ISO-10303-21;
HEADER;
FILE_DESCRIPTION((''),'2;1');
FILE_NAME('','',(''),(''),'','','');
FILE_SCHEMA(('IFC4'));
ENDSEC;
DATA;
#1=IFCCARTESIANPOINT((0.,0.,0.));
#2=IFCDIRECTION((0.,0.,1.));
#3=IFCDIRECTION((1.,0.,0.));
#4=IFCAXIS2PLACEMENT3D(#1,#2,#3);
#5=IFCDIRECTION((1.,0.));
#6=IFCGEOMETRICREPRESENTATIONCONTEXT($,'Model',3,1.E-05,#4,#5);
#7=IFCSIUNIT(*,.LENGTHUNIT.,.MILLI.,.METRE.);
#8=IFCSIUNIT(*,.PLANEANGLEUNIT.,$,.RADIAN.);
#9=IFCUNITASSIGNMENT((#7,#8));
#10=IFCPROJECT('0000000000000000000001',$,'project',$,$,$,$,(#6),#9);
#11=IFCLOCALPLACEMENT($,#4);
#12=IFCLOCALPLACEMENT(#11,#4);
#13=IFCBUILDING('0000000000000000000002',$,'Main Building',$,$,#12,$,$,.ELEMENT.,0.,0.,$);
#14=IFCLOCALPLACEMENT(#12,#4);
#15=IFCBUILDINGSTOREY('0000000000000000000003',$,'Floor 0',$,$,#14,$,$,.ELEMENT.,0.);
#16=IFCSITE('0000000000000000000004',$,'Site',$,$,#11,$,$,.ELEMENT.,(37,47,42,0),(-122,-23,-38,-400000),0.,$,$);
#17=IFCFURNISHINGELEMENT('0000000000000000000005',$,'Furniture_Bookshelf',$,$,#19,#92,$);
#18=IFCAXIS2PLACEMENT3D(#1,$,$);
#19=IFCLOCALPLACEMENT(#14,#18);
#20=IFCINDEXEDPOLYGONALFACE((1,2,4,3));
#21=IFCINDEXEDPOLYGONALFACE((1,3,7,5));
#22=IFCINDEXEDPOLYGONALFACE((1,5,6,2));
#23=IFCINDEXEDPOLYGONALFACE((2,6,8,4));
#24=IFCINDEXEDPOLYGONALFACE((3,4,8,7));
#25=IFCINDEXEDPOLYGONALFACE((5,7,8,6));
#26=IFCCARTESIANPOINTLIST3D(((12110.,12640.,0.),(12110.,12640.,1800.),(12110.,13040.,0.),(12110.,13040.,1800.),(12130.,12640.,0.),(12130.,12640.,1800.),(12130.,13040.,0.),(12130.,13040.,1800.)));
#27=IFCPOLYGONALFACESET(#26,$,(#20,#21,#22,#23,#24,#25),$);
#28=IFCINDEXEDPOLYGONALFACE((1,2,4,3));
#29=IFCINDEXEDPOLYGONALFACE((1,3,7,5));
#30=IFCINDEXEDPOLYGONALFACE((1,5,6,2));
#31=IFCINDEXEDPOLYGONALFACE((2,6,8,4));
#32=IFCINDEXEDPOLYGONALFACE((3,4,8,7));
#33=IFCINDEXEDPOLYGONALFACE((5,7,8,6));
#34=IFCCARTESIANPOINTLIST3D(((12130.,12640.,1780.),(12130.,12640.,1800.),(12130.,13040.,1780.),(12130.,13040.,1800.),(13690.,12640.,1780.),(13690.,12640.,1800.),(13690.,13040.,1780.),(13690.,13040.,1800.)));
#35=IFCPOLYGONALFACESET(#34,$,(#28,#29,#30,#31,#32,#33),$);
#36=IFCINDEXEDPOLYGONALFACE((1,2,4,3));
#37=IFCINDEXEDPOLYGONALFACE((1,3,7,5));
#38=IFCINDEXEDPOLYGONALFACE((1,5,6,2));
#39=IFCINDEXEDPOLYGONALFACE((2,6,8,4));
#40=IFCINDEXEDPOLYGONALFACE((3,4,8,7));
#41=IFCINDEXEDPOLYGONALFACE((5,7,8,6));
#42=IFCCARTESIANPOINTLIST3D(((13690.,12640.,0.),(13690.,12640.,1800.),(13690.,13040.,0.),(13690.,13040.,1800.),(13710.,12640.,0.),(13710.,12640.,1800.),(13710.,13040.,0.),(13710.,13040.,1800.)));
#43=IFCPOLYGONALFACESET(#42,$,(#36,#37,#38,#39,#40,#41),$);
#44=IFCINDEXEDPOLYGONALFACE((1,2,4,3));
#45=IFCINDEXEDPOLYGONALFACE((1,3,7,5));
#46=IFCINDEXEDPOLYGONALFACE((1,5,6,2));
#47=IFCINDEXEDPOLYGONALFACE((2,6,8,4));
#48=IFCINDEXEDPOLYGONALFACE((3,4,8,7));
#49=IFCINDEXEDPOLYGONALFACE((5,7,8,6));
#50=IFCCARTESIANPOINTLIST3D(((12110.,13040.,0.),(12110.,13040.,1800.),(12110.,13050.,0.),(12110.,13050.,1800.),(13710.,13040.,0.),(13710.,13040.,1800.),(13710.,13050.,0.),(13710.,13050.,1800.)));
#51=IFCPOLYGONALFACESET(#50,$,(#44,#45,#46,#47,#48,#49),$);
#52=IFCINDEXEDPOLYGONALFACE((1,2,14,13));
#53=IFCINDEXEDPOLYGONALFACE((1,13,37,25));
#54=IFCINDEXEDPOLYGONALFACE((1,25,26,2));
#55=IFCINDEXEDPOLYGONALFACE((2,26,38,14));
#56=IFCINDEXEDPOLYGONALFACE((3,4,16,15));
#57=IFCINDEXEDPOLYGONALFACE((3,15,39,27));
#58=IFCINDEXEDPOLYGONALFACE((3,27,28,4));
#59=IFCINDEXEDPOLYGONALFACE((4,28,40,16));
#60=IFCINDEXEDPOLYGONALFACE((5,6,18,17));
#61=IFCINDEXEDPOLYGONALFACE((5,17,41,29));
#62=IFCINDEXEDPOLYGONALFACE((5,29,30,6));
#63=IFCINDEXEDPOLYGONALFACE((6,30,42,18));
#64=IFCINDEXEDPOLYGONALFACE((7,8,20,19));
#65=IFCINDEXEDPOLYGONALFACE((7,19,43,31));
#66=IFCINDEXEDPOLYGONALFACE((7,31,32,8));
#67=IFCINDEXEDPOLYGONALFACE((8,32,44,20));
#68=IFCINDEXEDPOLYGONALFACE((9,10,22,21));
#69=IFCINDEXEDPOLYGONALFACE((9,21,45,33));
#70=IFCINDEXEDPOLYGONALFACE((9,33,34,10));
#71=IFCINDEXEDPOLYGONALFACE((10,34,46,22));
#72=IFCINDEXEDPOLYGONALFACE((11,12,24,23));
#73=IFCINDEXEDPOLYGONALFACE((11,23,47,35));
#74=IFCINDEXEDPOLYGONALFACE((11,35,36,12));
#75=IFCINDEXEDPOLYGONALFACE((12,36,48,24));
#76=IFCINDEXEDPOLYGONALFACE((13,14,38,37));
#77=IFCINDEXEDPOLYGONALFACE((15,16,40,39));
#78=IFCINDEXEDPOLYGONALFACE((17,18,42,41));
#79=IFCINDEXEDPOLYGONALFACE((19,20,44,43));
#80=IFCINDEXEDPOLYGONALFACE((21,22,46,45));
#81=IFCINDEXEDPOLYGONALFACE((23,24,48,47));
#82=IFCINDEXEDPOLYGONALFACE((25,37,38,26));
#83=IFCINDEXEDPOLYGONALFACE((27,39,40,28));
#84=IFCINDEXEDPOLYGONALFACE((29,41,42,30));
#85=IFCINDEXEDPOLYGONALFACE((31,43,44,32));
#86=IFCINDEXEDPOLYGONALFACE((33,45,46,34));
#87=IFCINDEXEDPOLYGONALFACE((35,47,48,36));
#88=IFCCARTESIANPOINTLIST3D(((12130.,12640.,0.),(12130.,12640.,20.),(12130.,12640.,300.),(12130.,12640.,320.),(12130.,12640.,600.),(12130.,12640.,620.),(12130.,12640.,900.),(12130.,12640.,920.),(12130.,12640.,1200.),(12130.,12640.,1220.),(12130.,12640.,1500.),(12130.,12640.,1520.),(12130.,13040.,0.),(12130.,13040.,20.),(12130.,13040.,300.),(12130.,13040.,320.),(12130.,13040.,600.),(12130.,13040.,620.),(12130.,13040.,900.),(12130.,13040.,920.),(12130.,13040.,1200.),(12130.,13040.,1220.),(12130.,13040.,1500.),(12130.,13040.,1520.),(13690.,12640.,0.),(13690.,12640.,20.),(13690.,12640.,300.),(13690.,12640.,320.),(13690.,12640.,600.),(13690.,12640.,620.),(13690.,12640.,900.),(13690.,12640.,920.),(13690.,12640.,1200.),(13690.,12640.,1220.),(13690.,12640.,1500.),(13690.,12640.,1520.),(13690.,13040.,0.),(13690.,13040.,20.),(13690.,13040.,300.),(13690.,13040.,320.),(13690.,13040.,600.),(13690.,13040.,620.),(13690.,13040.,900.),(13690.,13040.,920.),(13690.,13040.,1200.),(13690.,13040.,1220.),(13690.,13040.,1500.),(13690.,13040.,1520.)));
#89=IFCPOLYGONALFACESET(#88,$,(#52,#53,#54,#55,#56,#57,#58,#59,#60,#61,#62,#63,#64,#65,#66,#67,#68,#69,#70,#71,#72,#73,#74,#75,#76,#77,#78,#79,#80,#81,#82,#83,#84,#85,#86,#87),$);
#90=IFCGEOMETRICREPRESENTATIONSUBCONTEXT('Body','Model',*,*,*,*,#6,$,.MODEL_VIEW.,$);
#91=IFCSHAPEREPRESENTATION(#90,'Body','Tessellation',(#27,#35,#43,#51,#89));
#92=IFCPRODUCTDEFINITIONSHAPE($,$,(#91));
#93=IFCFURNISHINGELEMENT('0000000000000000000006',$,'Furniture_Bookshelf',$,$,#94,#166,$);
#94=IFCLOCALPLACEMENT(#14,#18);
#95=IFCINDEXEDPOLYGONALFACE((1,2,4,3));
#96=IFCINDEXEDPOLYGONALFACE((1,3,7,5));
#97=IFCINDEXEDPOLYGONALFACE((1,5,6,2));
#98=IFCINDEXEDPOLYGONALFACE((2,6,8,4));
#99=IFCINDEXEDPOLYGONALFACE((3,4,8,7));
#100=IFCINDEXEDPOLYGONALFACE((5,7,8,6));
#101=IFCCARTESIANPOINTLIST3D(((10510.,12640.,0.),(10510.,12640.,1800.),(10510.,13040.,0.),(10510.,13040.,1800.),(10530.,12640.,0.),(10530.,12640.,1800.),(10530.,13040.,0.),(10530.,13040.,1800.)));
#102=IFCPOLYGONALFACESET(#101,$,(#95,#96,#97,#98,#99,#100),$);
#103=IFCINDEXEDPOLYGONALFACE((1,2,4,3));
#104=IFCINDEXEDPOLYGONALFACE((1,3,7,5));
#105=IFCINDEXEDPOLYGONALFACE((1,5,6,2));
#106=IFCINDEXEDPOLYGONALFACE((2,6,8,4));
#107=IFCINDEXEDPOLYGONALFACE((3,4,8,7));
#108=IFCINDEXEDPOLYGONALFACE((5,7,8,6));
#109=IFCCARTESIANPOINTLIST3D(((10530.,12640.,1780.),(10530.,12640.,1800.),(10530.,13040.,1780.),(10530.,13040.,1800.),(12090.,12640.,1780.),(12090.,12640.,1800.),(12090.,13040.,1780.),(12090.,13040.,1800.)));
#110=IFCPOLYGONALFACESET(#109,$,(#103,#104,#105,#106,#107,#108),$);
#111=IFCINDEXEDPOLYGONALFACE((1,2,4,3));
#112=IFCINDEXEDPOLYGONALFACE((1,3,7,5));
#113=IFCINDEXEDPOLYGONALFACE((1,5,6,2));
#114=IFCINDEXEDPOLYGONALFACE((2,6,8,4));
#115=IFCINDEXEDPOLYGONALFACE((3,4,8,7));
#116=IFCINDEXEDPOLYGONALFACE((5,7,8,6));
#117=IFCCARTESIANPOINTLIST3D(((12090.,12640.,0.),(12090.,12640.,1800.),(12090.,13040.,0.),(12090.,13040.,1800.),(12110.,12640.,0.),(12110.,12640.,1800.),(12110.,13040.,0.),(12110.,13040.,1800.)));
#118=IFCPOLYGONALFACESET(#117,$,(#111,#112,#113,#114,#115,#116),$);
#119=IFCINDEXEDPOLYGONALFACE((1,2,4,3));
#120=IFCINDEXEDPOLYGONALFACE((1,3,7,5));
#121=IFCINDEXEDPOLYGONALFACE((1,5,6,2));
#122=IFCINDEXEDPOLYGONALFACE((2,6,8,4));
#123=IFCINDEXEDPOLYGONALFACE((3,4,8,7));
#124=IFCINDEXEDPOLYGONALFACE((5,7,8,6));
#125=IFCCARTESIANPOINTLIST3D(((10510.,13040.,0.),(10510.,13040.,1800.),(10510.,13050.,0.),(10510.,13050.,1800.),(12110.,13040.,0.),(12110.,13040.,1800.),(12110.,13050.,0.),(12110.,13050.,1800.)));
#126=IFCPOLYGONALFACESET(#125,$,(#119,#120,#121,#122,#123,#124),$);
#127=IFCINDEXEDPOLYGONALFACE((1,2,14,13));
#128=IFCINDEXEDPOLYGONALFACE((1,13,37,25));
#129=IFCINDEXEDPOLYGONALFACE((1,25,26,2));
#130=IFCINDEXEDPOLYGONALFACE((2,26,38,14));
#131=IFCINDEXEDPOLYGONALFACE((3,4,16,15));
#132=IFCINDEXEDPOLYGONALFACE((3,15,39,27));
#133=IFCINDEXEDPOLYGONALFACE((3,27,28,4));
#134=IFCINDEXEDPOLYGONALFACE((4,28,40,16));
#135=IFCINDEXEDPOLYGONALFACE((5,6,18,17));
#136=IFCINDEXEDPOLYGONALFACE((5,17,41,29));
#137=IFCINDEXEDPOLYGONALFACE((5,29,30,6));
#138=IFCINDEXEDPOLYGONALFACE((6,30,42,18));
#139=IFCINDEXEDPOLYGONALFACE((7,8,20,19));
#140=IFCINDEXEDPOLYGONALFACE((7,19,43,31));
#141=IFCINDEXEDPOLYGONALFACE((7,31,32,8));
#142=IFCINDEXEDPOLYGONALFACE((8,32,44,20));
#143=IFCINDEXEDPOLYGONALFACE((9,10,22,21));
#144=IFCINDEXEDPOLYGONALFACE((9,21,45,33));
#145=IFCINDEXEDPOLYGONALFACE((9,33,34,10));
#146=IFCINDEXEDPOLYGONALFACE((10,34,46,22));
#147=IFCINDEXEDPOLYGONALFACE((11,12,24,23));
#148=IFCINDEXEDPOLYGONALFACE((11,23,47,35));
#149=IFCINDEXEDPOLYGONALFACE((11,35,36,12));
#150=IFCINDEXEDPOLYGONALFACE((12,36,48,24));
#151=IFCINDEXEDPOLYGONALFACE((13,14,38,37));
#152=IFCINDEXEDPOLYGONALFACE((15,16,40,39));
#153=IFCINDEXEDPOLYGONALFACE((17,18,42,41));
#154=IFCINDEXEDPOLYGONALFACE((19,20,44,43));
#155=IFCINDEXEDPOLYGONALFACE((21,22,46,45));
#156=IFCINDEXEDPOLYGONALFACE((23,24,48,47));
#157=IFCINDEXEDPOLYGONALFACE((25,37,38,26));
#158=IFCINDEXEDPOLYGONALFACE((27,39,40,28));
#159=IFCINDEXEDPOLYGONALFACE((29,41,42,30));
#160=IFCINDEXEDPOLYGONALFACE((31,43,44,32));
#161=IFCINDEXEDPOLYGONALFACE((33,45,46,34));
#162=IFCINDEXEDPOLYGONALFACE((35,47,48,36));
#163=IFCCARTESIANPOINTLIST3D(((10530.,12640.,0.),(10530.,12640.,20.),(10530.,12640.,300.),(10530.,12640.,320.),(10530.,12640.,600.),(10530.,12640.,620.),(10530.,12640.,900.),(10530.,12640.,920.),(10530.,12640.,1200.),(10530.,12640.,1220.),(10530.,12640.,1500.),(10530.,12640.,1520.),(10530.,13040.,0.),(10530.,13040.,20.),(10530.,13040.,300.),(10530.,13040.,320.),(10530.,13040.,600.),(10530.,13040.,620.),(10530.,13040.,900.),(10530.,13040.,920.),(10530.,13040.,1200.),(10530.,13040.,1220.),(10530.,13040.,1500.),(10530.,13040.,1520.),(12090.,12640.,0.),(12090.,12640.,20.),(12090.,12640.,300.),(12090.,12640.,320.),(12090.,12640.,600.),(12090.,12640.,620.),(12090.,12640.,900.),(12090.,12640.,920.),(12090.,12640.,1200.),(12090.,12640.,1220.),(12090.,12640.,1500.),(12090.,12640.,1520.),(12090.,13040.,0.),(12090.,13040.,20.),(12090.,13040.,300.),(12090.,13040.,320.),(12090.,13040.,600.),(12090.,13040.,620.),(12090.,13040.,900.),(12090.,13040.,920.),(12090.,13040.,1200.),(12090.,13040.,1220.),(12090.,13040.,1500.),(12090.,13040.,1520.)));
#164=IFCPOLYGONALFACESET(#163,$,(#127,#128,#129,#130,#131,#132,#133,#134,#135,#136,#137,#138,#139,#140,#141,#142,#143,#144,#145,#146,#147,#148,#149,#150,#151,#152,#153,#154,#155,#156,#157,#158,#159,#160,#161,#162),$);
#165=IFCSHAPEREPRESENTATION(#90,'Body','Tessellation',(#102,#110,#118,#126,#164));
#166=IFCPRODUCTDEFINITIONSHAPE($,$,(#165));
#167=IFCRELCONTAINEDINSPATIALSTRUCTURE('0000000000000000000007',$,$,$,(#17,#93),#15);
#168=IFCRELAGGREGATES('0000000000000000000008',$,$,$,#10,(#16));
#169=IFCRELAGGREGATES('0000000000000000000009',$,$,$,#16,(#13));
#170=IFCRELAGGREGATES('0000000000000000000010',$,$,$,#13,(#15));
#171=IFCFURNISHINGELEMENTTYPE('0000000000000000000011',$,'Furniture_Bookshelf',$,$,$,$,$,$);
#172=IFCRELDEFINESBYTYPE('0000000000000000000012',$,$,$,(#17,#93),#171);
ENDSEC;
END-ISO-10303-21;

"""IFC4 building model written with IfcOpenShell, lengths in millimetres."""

from ifc_helpers import new_model, si_unit, direction, frame, frame_2d, origin_with_axes, origin_2d_with_axis, place, context, subcontext, project, spatial, rectangle, extrude, source, transform, mapped, type_object, type_shapes, element, save


model = new_model("IFC4")

# Units and contexts
model_context = context("Model", 3, precision=1e-05, world=origin_with_axes(), true_north=direction((1.0, 0.0)))
body_context = subcontext(model_context, "Body", "Model", "MODEL_VIEW")
ifc_project = project(units=[si_unit("LENGTHUNIT", "METRE", prefix="MILLI"), si_unit("PLANEANGLEUNIT", "RADIAN")], contexts=[model_context])

# Site, building, storey
site_placement = place(None, origin_with_axes())
site = spatial("IfcSite", under=ifc_project, at=site_placement, Name="Site", CompositionType="ELEMENT", RefLatitude=(37, 47, 42, 0), RefLongitude=(-122, -23, -38, -400000), RefElevation=0.0)
building_placement = place(site_placement, origin_with_axes())
building = spatial("IfcBuilding", under=site, at=building_placement, Name="Main Building", CompositionType="ELEMENT", ElevationOfRefHeight=0.0, ElevationOfTerrain=0.0)
storey_placement = place(building_placement, origin_with_axes())
storey = spatial("IfcBuildingStorey", under=building, at=storey_placement, Name="Floor 0", CompositionType="ELEMENT", Elevation=0.0)

# Furnishing elements
furnishing_element_type_1 = type_object("IfcFurnishingElementType", Name="Furniture_Bookshelf")
shared_shape_1 = source(origin_with_axes(), body_context, "Body", "SweptSolid", [
    extrude(rectangle(XDim=400.0, YDim=20.0, at=frame_2d((0.0, 0.0), x_axis=(0.0, 1.0))), frame((10.0, 200.0, 0.0), z_axis=(0.0, 0.0, 1.0), x_axis=(1.0, 0.0, 0.0)), (0.0, 0.0, 1.0), 1800.0),
])
shared_shape_2 = source(origin_with_axes(), body_context, "Body", "SweptSolid", [
    extrude(rectangle(XDim=1560.0, YDim=400.0, at=origin_2d_with_axis()), frame((800.0, 200.0, 1780.0), z_axis=(0.0, 0.0, 1.0), x_axis=(1.0, 0.0, 0.0)), (0.0, 0.0, 1.0), 20.0),
])
shared_shape_3 = source(origin_with_axes(), body_context, "Body", "SweptSolid", [
    extrude(rectangle(XDim=400.0, YDim=20.0, at=frame_2d((0.0, 0.0), x_axis=(0.0, 1.0))), frame((1590.0, 200.0, 0.0), z_axis=(0.0, 0.0, 1.0), x_axis=(1.0, 0.0, 0.0)), (0.0, 0.0, 1.0), 1800.0),
])
shared_shape_4 = source(origin_with_axes(), body_context, "Body", "SweptSolid", [
    extrude(rectangle(XDim=1600.0, YDim=10.0, at=origin_2d_with_axis()), frame((800.0, 405.0, 0.0), z_axis=(0.0, 0.0, 1.0), x_axis=(1.0, 0.0, 0.0)), (0.0, 0.0, 1.0), 1800.0),
])
shared_shape_5 = source(origin_with_axes(), body_context, "Body", "SweptSolid", [
    extrude(rectangle(XDim=1560.0, YDim=400.0, at=origin_2d_with_axis()), frame((200.0, 50.0, -10.0), z_axis=(0.0, 0.0, 1.0), x_axis=(1.0, 0.0, 0.0)), (0.0, 0.0, 1.0), 20.0),
])
shared_shape_6 = source(origin_with_axes(), body_context, "Body", "MappedRepresentation", [
    mapped(shared_shape_5, transform((0.0, 0.0, 0.0), x_axis=(1.0, 0.0, 0.0), y_axis=(0.0, 1.0, 0.0), z_axis=(0.0, 0.0, 1.0), scale=1.0)),
    mapped(shared_shape_5, transform((0.0, 0.0, 300.0), x_axis=(1.0, 0.0, 0.0), y_axis=(0.0, 1.0, 0.0), z_axis=(0.0, 0.0, 1.0), scale=1.0)),
    mapped(shared_shape_5, transform((0.0, 0.0, 600.0), x_axis=(1.0, 0.0, 0.0), y_axis=(0.0, 1.0, 0.0), z_axis=(0.0, 0.0, 1.0), scale=1.0)),
    mapped(shared_shape_5, transform((0.0, 0.0, 900.0), x_axis=(1.0, 0.0, 0.0), y_axis=(0.0, 1.0, 0.0), z_axis=(0.0, 0.0, 1.0), scale=1.0)),
    mapped(shared_shape_5, transform((0.0, 0.0, 1200.0), x_axis=(1.0, 0.0, 0.0), y_axis=(0.0, 1.0, 0.0), z_axis=(0.0, 0.0, 1.0), scale=1.0)),
    mapped(shared_shape_5, transform((0.0, 0.0, 1500.0), x_axis=(1.0, 0.0, 0.0), y_axis=(0.0, 1.0, 0.0), z_axis=(0.0, 0.0, 1.0), scale=1.0)),
])
shared_shape_7 = source(origin_with_axes(), body_context, "Body", "MappedRepresentation", [
    mapped(shared_shape_1, transform((0.0, 0.0, 0.0), x_axis=(1.0, 0.0, 0.0), y_axis=(0.0, 1.0, 0.0), z_axis=(0.0, 0.0, 1.0), scale=1.0)),
    mapped(shared_shape_2, transform((0.0, 0.0, 0.0), x_axis=(1.0, 0.0, 0.0), y_axis=(0.0, 1.0, 0.0), z_axis=(0.0, 0.0, 1.0), scale=1.0)),
    mapped(shared_shape_3, transform((0.0, 0.0, 0.0), x_axis=(1.0, 0.0, 0.0), y_axis=(0.0, 1.0, 0.0), z_axis=(0.0, 0.0, 1.0), scale=1.0)),
    mapped(shared_shape_4, transform((0.0, 0.0, 0.0), x_axis=(1.0, 0.0, 0.0), y_axis=(0.0, 1.0, 0.0), z_axis=(0.0, 0.0, 1.0), scale=1.0)),
    mapped(shared_shape_6, transform((600.0, 150.0, 10.0), x_axis=(1.0, 0.0, 0.0), y_axis=(0.0, 1.0, 0.0), z_axis=(0.0, 0.0, 1.0), scale=1.0)),
])
type_shapes(furnishing_element_type_1, [shared_shape_7])
for number, where, z_axis, x_axis, name in (
    (1, (12110.0, 12640.0, 0.0), (0.0, 0.0, 1.0), (1.0, 0.0, 0.0), "Furniture_Bookshelf"),
    (2, (10510.0, 12640.0, 0.0), (0.0, 0.0, 1.0), (1.0, 0.0, 0.0), "Furniture_Bookshelf"),
):
    element("IfcFurnishingElement", number, at=place(storey_placement, frame(where, z_axis=z_axis, x_axis=x_axis)), inside=storey, type_object=furnishing_element_type_1, Name=name, context=body_context, shape_type="MappedRepresentation", body=[
        mapped(shared_shape_7, transform((0.0, 0.0, 0.0), x_axis=(1.0, 0.0, 0.0), y_axis=(0.0, 1.0, 0.0), z_axis=(0.0, 0.0, 1.0), scale=1.0)),
    ])

save(model, "model.ifc")
